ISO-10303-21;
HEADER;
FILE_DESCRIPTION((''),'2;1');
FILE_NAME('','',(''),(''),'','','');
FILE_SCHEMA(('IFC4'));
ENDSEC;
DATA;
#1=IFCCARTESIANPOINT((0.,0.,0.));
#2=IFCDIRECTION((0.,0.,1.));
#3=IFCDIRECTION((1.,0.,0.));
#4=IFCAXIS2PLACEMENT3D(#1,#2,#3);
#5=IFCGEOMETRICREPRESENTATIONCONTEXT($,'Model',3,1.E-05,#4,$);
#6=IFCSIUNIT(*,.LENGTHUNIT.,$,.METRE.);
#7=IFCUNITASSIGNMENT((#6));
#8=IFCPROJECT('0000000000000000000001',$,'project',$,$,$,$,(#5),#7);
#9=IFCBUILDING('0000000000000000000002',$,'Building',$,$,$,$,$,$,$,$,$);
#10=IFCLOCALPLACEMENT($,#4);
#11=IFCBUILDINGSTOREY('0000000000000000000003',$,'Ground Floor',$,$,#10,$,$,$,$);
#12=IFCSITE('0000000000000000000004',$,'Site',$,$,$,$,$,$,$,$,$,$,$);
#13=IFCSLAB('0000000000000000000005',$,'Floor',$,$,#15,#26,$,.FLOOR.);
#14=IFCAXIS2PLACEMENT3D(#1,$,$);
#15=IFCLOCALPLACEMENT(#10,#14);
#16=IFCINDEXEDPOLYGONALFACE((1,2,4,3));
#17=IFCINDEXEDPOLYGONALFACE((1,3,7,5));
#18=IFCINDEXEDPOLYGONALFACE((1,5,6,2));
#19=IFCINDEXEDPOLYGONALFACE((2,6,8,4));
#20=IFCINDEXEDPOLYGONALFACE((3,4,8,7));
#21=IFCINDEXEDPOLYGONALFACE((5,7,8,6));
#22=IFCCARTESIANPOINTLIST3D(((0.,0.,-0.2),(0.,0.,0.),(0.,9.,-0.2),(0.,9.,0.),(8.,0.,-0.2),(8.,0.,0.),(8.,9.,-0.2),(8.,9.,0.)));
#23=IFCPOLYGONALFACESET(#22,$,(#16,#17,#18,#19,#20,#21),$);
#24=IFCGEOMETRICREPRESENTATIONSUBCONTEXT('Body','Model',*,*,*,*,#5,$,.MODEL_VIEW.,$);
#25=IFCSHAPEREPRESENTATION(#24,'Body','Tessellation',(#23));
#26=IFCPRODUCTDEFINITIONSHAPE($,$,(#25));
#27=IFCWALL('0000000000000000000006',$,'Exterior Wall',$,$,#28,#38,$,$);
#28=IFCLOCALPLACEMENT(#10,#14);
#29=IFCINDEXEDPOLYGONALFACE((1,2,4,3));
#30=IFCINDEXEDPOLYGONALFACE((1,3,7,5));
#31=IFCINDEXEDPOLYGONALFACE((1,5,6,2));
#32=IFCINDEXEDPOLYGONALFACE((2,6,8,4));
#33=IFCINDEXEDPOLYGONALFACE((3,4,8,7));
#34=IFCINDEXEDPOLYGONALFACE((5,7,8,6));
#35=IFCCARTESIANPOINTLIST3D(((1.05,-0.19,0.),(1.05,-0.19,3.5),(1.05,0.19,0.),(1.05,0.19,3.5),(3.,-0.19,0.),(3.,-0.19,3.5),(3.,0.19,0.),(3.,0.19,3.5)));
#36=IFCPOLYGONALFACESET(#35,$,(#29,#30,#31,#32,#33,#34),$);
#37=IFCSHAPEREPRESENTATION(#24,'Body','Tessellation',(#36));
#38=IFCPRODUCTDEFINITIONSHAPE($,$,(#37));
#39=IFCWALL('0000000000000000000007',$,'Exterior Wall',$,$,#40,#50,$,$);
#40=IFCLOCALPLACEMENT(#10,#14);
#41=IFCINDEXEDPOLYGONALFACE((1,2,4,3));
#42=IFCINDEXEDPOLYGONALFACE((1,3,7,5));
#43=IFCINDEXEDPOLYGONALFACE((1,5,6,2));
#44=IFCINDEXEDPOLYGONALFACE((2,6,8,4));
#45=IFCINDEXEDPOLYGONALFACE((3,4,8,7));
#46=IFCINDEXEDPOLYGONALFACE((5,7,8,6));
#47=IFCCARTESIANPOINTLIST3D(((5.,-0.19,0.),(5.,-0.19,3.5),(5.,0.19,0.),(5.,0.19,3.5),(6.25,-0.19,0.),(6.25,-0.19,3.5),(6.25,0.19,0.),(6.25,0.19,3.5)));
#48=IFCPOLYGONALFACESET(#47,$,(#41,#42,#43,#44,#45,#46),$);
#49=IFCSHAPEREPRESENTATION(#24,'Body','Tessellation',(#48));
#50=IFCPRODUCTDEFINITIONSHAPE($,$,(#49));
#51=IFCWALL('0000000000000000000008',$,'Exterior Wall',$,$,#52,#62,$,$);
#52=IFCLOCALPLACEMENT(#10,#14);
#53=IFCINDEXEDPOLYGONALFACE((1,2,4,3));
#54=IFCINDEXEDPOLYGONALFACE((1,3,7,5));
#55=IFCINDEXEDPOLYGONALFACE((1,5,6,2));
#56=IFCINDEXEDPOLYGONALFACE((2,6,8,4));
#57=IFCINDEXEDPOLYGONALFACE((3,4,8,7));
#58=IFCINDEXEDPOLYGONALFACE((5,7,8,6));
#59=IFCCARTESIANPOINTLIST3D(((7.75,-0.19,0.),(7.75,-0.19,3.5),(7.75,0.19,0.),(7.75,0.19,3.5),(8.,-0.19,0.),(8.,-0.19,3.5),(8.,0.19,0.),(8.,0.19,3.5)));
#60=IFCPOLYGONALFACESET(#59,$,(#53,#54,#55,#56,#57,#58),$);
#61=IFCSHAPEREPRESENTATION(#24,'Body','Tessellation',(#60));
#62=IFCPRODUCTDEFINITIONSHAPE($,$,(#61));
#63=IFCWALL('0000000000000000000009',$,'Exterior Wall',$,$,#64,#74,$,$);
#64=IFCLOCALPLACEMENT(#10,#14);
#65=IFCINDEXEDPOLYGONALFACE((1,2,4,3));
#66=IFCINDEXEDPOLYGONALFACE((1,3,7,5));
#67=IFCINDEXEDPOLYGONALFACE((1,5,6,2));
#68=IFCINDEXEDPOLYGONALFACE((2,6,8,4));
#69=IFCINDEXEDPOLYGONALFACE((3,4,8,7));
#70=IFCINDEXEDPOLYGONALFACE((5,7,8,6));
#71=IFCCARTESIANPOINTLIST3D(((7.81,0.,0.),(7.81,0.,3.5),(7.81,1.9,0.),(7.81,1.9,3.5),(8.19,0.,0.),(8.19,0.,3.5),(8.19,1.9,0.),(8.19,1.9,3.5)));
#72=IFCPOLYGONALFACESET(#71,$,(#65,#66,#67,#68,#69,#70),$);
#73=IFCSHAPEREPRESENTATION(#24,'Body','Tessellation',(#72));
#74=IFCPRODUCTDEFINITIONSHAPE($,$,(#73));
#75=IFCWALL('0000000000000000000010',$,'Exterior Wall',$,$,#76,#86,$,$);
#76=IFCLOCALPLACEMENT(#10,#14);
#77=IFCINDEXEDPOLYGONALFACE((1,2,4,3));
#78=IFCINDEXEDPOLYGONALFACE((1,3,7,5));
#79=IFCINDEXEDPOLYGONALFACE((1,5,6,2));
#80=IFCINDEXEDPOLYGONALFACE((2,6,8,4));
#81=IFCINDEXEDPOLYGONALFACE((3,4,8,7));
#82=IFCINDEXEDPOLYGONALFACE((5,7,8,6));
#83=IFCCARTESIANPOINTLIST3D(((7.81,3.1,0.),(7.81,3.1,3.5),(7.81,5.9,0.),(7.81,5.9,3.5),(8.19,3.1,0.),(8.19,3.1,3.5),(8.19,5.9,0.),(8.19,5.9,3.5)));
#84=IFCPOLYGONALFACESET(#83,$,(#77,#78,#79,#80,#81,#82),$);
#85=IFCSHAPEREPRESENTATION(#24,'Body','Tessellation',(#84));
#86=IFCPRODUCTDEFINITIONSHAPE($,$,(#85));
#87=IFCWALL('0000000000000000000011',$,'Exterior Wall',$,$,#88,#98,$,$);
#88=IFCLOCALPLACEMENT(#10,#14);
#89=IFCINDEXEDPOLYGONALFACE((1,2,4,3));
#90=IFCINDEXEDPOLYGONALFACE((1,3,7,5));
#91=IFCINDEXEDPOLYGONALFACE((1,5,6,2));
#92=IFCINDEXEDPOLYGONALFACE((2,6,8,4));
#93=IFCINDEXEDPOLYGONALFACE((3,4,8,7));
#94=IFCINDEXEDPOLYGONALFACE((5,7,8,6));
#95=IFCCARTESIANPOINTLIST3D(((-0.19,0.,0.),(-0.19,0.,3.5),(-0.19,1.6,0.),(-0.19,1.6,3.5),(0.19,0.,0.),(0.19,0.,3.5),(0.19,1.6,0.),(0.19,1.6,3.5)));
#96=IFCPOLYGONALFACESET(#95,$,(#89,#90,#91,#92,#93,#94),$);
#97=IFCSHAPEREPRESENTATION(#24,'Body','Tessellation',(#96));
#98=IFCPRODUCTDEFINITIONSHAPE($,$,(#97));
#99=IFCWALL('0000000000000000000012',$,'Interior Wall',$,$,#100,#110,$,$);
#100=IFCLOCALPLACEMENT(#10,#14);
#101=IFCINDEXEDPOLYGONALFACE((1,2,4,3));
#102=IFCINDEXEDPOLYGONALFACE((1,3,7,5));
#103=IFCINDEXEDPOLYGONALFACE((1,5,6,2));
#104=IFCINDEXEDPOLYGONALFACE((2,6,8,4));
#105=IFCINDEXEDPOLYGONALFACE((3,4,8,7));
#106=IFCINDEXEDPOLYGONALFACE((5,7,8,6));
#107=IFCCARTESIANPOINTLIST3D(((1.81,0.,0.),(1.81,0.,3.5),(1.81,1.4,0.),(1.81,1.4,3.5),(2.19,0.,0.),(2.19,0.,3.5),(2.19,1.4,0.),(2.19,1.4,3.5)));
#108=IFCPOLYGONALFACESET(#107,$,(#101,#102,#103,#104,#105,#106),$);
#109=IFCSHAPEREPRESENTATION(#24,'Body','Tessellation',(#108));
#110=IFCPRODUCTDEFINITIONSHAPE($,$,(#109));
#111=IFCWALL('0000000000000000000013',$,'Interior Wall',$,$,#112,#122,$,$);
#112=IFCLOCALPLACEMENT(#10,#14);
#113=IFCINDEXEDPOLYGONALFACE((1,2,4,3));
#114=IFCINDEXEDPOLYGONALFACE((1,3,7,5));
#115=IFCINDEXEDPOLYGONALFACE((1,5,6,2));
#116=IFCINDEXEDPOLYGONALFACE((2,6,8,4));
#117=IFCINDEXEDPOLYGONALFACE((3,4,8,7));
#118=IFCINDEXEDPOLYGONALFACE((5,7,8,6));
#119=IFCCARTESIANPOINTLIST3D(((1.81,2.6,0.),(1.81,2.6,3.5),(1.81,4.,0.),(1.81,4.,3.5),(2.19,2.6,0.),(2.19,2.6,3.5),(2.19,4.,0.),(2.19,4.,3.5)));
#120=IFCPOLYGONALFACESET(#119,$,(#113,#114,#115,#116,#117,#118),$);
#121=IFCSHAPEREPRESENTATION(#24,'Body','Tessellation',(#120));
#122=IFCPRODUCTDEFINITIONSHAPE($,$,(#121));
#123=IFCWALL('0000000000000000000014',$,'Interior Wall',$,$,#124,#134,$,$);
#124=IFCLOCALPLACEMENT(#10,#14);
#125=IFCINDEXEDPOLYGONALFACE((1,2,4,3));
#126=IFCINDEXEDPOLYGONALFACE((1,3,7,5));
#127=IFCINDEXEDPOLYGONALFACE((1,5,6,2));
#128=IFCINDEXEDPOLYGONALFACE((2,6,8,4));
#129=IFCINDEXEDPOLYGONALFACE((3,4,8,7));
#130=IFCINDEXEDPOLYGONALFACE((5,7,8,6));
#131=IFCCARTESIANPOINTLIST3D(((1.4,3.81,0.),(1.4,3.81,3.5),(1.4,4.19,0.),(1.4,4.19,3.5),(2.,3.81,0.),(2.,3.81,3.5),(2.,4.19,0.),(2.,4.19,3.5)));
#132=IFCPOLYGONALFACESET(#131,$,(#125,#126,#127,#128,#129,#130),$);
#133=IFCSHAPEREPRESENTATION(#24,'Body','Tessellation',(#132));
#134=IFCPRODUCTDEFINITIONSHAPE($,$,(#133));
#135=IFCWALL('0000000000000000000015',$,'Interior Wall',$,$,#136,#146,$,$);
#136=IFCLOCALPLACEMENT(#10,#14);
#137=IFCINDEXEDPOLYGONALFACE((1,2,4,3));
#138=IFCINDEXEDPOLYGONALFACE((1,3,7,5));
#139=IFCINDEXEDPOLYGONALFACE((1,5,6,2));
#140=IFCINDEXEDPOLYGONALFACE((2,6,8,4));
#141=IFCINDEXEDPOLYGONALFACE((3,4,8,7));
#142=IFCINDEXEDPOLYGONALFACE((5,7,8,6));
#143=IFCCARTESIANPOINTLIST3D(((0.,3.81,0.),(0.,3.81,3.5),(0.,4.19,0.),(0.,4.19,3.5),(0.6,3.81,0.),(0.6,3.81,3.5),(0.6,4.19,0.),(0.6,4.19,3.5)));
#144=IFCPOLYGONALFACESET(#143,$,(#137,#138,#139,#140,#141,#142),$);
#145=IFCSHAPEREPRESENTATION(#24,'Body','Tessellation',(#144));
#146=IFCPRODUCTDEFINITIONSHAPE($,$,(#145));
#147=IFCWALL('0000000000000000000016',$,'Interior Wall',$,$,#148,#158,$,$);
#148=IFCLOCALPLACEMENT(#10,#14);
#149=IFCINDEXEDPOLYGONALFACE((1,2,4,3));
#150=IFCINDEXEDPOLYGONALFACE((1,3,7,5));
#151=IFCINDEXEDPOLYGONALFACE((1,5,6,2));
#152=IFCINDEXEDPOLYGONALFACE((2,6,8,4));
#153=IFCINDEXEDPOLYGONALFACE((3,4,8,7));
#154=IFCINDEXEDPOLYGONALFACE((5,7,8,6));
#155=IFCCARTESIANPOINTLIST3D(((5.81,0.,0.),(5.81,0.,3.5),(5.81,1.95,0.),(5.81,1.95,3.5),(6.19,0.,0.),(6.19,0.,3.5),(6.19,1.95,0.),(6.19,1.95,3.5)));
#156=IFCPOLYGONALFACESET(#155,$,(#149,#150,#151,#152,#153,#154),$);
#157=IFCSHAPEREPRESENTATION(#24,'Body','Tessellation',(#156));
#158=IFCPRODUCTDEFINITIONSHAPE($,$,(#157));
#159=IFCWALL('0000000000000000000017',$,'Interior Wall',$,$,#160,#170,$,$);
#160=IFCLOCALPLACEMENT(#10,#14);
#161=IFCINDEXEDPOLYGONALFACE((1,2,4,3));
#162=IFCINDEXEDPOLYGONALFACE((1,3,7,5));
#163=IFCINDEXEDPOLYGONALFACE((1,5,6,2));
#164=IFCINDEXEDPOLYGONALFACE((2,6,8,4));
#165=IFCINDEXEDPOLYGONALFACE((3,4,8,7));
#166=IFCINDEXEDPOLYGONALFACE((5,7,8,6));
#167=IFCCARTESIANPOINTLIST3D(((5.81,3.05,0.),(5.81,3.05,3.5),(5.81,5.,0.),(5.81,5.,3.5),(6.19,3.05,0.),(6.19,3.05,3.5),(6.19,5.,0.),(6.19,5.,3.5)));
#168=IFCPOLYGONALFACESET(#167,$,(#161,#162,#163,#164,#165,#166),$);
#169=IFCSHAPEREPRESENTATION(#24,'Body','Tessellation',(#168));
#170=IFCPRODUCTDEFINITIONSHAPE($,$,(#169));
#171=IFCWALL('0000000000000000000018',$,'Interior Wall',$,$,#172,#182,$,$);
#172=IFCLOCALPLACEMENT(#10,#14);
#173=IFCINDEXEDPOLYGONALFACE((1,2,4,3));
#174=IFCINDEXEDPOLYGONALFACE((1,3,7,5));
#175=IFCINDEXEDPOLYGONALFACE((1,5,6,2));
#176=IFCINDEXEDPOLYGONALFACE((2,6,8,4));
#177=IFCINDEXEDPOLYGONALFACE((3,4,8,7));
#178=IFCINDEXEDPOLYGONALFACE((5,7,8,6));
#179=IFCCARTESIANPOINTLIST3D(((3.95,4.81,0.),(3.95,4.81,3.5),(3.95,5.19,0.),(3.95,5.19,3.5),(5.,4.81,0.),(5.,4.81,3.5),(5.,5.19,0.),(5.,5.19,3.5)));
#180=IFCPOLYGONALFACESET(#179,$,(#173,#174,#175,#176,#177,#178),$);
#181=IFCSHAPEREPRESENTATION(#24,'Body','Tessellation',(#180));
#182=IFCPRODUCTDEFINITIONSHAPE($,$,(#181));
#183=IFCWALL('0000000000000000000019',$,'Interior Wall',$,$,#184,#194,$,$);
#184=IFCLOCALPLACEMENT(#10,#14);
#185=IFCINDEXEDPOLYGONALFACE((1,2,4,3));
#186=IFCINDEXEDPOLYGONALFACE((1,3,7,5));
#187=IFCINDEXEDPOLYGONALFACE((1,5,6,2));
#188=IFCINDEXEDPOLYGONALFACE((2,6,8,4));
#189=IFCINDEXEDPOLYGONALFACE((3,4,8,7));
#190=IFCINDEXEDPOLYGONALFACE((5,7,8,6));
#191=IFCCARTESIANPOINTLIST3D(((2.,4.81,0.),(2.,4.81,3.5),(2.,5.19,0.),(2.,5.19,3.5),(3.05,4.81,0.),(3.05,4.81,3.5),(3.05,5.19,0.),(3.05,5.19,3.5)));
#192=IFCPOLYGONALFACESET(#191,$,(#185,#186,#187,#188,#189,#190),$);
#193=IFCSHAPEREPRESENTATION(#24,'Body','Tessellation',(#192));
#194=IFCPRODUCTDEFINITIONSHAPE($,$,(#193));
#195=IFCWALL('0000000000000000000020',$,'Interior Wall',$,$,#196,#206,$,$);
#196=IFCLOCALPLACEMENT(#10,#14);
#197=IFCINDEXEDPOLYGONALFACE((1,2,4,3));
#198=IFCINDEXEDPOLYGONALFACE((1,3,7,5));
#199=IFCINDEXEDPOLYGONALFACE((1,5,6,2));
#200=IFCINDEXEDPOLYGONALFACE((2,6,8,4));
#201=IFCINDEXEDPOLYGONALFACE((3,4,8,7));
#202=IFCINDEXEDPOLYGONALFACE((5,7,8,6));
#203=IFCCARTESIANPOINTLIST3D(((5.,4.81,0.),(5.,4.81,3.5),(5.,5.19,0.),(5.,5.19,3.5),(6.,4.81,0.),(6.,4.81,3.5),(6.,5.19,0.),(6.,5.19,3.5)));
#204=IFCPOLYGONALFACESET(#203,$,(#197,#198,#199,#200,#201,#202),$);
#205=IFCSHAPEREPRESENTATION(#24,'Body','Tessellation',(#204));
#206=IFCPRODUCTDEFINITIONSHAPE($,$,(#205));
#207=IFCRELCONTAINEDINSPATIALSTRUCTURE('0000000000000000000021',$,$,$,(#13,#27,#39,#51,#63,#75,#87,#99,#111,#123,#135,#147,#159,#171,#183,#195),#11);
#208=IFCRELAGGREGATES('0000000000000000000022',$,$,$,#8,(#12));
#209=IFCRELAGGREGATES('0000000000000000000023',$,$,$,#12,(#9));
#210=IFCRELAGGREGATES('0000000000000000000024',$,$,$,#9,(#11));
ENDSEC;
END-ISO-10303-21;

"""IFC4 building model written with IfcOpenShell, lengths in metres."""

from ifc_helpers import new_model, si_unit, frame, origin_with_axes, place, context, subcontext, project, spatial, indexed_curve, outline, extrude, element, save


model = new_model("IFC4")

# Units and contexts
model_context = context("Model", 3, precision=1e-05, world=origin_with_axes())
body_context = subcontext(model_context, "Body", "Model", "MODEL_VIEW")
ifc_project = project(units=[si_unit("LENGTHUNIT", "METRE")], contexts=[model_context])

# Site, building, storey
site = spatial("IfcSite", under=ifc_project, Name="Site")
building = spatial("IfcBuilding", under=site, Name="Building")
storey_placement = place(None, origin_with_axes())
storey = spatial("IfcBuildingStorey", under=building, at=storey_placement, Name="Ground Floor")

# Slab
slab_placement = place(storey_placement, frame((0.0, 0.0, -0.2), z_axis=(0.0, 0.0, 1.0), x_axis=(1.0, 0.0, 0.0)))
element("IfcSlab", 1, at=slab_placement, inside=storey, Name="Floor", PredefinedType="FLOOR", context=body_context, shape_type="SweptSolid", body=[
    extrude(outline(indexed_curve([(0.0, 0.0), (8.0, 0.0), (8.0, 9.0), (0.0, 9.0)])), None, (0.0, 0.0, 1.0), 0.2),
])

# Walls
wall_1_placement = place(storey_placement, frame((1.05, 0.0, 0.0), z_axis=(0.0, 0.0, 1.0), x_axis=(1.0, 0.0, 0.0)))
element("IfcWall", 2, at=wall_1_placement, inside=storey, Name="Exterior Wall", context=body_context, shape_type="SweptSolid", body=[
    extrude(outline(indexed_curve([(0.0, 0.0), (0.0, 0.38), (1.95, 0.38), (1.95, 0.0), (0.0, 0.0)], self_intersect=False)), frame((0.0, -0.19, 0.0), z_axis=(0.0, 0.0, 1.0), x_axis=(1.0, 0.0, 0.0)), (0.0, 0.0, 1.0), 3.5),
])
wall_2_placement = place(storey_placement, frame((5.0, 0.0, 0.0), z_axis=(0.0, 0.0, 1.0), x_axis=(1.0, 0.0, 0.0)))
element("IfcWall", 3, at=wall_2_placement, inside=storey, Name="Exterior Wall", context=body_context, shape_type="SweptSolid", body=[
    extrude(outline(indexed_curve([(0.0, 0.0), (0.0, 0.38), (1.25, 0.38), (1.25, 0.0), (0.0, 0.0)], self_intersect=False)), frame((0.0, -0.19, 0.0), z_axis=(0.0, 0.0, 1.0), x_axis=(1.0, 0.0, 0.0)), (0.0, 0.0, 1.0), 3.5),
])
wall_3_placement = place(storey_placement, frame((7.75, 0.0, 0.0), z_axis=(0.0, 0.0, 1.0), x_axis=(1.0, 0.0, 0.0)))
element("IfcWall", 4, at=wall_3_placement, inside=storey, Name="Exterior Wall", context=body_context, shape_type="SweptSolid", body=[
    extrude(outline(indexed_curve([(0.0, 0.0), (0.0, 0.38), (0.25, 0.38), (0.25, 0.0), (0.0, 0.0)], self_intersect=False)), frame((0.0, -0.19, 0.0), z_axis=(0.0, 0.0, 1.0), x_axis=(1.0, 0.0, 0.0)), (0.0, 0.0, 1.0), 3.5),
])
wall_4_placement = place(storey_placement, frame((8.0, 0.0, 0.0), z_axis=(0.0, 0.0, 1.0), x_axis=(0.0, 1.0, 0.0)))
element("IfcWall", 5, at=wall_4_placement, inside=storey, Name="Exterior Wall", context=body_context, shape_type="SweptSolid", body=[
    extrude(outline(indexed_curve([(0.0, 0.0), (0.0, 0.38), (1.9, 0.38), (1.9, 0.0), (0.0, 0.0)], self_intersect=False)), frame((0.0, -0.19, 0.0), z_axis=(0.0, 0.0, 1.0), x_axis=(1.0, 0.0, 0.0)), (0.0, 0.0, 1.0), 3.5),
])
wall_5_placement = place(storey_placement, frame((8.0, 3.1, 0.0), z_axis=(0.0, 0.0, 1.0), x_axis=(0.0, 1.0, 0.0)))
element("IfcWall", 6, at=wall_5_placement, inside=storey, Name="Exterior Wall", context=body_context, shape_type="SweptSolid", body=[
    extrude(outline(indexed_curve([(0.0, 0.0), (0.0, 0.38), (2.8, 0.38), (2.8, 0.0), (0.0, 0.0)], self_intersect=False)), frame((0.0, -0.19, 0.0), z_axis=(0.0, 0.0, 1.0), x_axis=(1.0, 0.0, 0.0)), (0.0, 0.0, 1.0), 3.5),
])
wall_6_placement = place(storey_placement, frame((0.0, 1.6, 0.0), z_axis=(0.0, 0.0, 1.0), x_axis=(0.0, -1.0, 0.0)))
element("IfcWall", 7, at=wall_6_placement, inside=storey, Name="Exterior Wall", context=body_context, shape_type="SweptSolid", body=[
    extrude(outline(indexed_curve([(0.0, 0.0), (0.0, 0.38), (1.6, 0.38), (1.6, 0.0), (0.0, 0.0)], self_intersect=False)), frame((0.0, -0.19, 0.0), z_axis=(0.0, 0.0, 1.0), x_axis=(1.0, 0.0, 0.0)), (0.0, 0.0, 1.0), 3.5),
])
for number, where, z_axis, x_axis, name in (
    (8, (2.0, 0.0, 0.0), (0.0, 0.0, 1.0), (0.0, 1.0, 0.0), "Interior Wall"),
    (9, (2.0, 2.6, 0.0), (0.0, 0.0, 1.0), (0.0, 1.0, 0.0), "Interior Wall"),
):
    element("IfcWall", number, at=place(storey_placement, frame(where, z_axis=z_axis, x_axis=x_axis)), inside=storey, Name=name, context=body_context, shape_type="SweptSolid", body=[
        extrude(outline(indexed_curve([(0.0, 0.0), (0.0, 0.38), (1.4, 0.38), (1.4, 0.0), (0.0, 0.0)], self_intersect=False)), frame((0.0, -0.19, 0.0), z_axis=(0.0, 0.0, 1.0), x_axis=(1.0, 0.0, 0.0)), (0.0, 0.0, 1.0), 3.5),
    ])
for number, where, z_axis, x_axis, name in (
    (10, (2.0, 4.0, 0.0), (0.0, 0.0, 1.0), (-1.0, 0.0, 0.0), "Interior Wall"),
    (11, (0.6, 4.0, 0.0), (0.0, 0.0, 1.0), (-1.0, 0.0, 0.0), "Interior Wall"),
):
    element("IfcWall", number, at=place(storey_placement, frame(where, z_axis=z_axis, x_axis=x_axis)), inside=storey, Name=name, context=body_context, shape_type="SweptSolid", body=[
        extrude(outline(indexed_curve([(0.0, 0.0), (0.0, 0.38), (0.6, 0.38), (0.6, 0.0), (0.0, 0.0)], self_intersect=False)), frame((0.0, -0.19, 0.0), z_axis=(0.0, 0.0, 1.0), x_axis=(1.0, 0.0, 0.0)), (0.0, 0.0, 1.0), 3.5),
    ])
wall_7_placement = place(storey_placement, frame((6.0, 0.0, 0.0), z_axis=(0.0, 0.0, 1.0), x_axis=(0.0, 1.0, 0.0)))
element("IfcWall", 12, at=wall_7_placement, inside=storey, Name="Interior Wall", context=body_context, shape_type="SweptSolid", body=[
    extrude(outline(indexed_curve([(0.0, 0.0), (0.0, 0.38), (1.95, 0.38), (1.95, 0.0), (0.0, 0.0)], self_intersect=False)), frame((0.0, -0.19, 0.0), z_axis=(0.0, 0.0, 1.0), x_axis=(1.0, 0.0, 0.0)), (0.0, 0.0, 1.0), 3.5),
])
wall_8_placement = place(storey_placement, frame((6.0, 3.05, 0.0), z_axis=(0.0, 0.0, 1.0), x_axis=(0.0, 1.0, 0.0)))
element("IfcWall", 13, at=wall_8_placement, inside=storey, Name="Interior Wall", context=body_context, shape_type="SweptSolid", body=[
    extrude(outline(indexed_curve([(0.0, 0.0), (0.0, 0.38), (1.95, 0.38), (1.95, 0.0), (0.0, 0.0)], self_intersect=False)), frame((0.0, -0.19, 0.0), z_axis=(0.0, 0.0, 1.0), x_axis=(1.0, 0.0, 0.0)), (0.0, 0.0, 1.0), 3.5),
])
for number, where, z_axis, x_axis, name in (
    (14, (5.0, 5.0, 0.0), (0.0, 0.0, 1.0), (-1.0, 0.0, 0.0), "Interior Wall"),
    (15, (3.05, 5.0, 0.0), (0.0, 0.0, 1.0), (-1.0, 0.0, 0.0), "Interior Wall"),
):
    element("IfcWall", number, at=place(storey_placement, frame(where, z_axis=z_axis, x_axis=x_axis)), inside=storey, Name=name, context=body_context, shape_type="SweptSolid", body=[
        extrude(outline(indexed_curve([(0.0, 0.0), (0.0, 0.38), (1.05, 0.38), (1.05, 0.0), (0.0, 0.0)], self_intersect=False)), frame((0.0, -0.19, 0.0), z_axis=(0.0, 0.0, 1.0), x_axis=(1.0, 0.0, 0.0)), (0.0, 0.0, 1.0), 3.5),
    ])
for number, where, z_axis, x_axis, name in (
    (16, (6.0, 5.0, 0.0), (0.0, 0.0, 1.0), (-1.0, 0.0, 0.0), "Interior Wall"),
):
    element("IfcWall", number, at=place(storey_placement, frame(where, z_axis=z_axis, x_axis=x_axis)), inside=storey, Name=name, context=body_context, shape_type="SweptSolid", body=[
        extrude(outline(indexed_curve([(0.0, 0.0), (0.0, 0.38), (1.0, 0.38), (1.0, 0.0), (0.0, 0.0)], self_intersect=False)), frame((0.0, -0.19, 0.0), z_axis=(0.0, 0.0, 1.0), x_axis=(1.0, 0.0, 0.0)), (0.0, 0.0, 1.0), 3.5),
    ])

save(model, "model.ifc")
